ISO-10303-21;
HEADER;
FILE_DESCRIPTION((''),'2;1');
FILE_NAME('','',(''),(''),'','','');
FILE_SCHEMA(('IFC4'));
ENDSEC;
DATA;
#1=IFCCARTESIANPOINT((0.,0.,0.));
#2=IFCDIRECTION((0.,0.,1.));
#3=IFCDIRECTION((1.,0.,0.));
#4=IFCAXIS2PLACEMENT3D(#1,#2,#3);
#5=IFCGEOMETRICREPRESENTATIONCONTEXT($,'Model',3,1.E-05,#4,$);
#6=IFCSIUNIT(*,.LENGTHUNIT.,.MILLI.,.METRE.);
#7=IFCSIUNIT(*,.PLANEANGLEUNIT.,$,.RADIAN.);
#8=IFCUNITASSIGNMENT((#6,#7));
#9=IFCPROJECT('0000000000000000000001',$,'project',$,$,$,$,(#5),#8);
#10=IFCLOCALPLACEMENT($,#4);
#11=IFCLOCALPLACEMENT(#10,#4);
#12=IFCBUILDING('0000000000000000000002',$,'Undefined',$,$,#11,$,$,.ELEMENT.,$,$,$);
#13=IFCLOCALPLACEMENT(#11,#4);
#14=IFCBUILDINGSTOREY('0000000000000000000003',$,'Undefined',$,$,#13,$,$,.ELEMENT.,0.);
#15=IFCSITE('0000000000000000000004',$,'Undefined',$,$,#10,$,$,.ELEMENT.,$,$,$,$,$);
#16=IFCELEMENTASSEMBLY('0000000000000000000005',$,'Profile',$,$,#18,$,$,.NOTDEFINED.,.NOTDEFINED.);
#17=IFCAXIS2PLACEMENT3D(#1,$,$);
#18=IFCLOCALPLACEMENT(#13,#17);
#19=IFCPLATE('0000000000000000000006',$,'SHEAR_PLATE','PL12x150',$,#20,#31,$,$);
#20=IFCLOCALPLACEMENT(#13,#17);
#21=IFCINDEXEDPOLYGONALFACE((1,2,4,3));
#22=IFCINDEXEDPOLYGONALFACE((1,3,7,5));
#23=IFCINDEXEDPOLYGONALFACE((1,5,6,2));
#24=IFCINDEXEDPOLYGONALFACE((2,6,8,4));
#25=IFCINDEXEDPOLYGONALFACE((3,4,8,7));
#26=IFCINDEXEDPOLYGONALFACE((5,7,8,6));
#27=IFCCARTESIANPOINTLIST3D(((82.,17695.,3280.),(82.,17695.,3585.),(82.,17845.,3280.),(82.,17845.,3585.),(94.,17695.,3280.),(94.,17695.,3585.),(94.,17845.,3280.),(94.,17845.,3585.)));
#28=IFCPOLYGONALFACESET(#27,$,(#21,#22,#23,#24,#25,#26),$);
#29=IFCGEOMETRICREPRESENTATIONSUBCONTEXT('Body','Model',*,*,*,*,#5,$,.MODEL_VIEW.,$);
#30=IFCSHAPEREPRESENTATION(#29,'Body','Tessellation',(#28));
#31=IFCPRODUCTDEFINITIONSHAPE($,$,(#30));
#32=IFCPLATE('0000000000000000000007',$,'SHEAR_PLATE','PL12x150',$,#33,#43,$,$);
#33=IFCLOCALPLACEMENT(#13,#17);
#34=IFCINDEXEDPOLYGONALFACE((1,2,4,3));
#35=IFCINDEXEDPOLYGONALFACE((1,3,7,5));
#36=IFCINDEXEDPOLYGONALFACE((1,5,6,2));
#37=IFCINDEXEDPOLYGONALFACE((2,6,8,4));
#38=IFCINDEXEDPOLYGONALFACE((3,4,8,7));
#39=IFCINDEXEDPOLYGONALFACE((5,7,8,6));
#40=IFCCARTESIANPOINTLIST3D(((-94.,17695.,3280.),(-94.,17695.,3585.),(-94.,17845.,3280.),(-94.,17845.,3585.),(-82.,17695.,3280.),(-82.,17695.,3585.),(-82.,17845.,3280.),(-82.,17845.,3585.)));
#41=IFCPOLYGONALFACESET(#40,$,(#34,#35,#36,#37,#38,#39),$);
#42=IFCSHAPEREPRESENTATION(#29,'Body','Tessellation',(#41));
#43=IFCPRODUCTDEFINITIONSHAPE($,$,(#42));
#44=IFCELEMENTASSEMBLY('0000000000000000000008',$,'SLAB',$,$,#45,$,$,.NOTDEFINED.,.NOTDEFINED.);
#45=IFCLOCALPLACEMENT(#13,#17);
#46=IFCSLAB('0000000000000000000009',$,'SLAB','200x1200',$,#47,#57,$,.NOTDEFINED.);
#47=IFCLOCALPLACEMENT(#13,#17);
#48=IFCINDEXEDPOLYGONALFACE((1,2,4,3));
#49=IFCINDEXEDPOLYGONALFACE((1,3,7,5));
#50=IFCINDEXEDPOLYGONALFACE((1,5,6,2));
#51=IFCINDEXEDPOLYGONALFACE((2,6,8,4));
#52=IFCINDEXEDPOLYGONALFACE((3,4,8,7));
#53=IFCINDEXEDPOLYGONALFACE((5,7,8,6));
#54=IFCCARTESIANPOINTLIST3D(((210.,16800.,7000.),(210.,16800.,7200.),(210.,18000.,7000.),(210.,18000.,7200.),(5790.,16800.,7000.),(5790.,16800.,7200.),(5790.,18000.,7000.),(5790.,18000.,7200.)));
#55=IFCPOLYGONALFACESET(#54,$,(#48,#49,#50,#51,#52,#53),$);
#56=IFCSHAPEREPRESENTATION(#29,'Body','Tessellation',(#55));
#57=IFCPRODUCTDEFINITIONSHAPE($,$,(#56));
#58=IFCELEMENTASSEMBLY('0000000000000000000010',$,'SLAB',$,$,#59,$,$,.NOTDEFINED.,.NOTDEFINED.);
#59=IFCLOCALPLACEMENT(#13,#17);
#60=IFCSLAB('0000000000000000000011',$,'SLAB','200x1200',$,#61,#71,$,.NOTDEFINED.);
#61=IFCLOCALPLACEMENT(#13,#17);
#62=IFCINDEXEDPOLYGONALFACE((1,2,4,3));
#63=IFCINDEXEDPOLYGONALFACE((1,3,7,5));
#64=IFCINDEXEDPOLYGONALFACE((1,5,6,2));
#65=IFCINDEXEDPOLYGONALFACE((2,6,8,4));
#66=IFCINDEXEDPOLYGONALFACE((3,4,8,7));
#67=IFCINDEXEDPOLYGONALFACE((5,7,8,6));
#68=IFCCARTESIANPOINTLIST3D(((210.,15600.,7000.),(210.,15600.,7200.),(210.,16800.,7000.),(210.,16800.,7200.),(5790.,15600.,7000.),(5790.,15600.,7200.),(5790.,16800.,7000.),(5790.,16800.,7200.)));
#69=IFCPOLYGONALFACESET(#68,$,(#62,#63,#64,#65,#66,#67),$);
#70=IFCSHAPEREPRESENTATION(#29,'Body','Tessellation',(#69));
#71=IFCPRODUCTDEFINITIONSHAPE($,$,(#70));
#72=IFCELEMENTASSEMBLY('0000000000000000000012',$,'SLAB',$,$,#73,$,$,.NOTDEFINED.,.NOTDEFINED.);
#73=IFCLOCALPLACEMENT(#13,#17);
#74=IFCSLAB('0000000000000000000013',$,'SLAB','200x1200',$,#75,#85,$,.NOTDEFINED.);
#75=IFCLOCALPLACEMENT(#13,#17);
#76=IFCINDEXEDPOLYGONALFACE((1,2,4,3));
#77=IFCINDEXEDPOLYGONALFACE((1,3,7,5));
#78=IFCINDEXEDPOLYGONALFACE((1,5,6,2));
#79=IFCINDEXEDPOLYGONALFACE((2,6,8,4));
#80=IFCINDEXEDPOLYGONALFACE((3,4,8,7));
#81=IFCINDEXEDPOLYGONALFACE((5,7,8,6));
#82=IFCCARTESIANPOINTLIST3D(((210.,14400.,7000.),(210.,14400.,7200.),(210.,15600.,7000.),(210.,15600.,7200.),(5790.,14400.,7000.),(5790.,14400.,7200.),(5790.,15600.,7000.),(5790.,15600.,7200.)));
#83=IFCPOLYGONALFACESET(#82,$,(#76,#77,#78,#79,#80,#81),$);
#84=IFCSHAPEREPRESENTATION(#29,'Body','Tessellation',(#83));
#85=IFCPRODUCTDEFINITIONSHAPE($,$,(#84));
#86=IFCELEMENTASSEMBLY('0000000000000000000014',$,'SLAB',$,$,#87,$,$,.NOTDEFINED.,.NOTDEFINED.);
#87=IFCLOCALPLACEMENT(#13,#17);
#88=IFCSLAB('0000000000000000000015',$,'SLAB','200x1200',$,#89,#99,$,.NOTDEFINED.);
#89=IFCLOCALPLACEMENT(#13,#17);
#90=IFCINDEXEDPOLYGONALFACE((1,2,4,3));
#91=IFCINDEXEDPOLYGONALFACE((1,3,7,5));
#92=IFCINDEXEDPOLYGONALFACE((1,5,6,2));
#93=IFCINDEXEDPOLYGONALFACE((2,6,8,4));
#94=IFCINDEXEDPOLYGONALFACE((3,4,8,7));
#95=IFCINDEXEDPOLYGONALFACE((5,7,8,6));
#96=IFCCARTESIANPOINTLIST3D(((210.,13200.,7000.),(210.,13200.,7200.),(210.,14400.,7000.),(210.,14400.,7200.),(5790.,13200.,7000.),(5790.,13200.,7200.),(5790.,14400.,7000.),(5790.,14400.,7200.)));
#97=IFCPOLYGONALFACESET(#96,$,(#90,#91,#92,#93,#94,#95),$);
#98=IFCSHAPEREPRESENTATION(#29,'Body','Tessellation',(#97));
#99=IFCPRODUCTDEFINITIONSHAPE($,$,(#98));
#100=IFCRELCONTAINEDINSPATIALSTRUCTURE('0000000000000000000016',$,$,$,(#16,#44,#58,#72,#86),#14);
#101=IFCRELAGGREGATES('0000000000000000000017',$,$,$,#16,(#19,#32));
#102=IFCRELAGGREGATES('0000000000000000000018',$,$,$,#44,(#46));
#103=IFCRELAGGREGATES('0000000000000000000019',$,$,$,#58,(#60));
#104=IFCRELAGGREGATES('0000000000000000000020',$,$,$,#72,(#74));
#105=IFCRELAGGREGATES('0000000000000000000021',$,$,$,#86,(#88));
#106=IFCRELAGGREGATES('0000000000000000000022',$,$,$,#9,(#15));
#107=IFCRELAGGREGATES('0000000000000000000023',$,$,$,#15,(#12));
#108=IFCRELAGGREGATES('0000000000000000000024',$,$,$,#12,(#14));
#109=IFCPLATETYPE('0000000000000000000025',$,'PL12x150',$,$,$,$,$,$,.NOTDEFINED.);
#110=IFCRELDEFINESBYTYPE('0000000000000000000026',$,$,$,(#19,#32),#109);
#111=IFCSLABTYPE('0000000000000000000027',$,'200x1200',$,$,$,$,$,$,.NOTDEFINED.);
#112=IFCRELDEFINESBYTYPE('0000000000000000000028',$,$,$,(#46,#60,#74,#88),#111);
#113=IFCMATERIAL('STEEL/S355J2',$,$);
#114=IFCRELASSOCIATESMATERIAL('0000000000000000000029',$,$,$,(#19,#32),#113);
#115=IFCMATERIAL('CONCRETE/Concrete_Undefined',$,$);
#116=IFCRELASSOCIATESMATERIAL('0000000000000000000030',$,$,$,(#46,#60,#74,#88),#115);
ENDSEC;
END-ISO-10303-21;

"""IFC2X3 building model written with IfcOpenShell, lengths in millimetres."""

from ifc_helpers import new_model, si_unit, frame, origin_with_axes, place, context, subcontext, project, spatial, polyline, outline, extrude, material, type_object, element, aggregate, save


model = new_model("IFC2X3")

# Units and contexts
model_context = context("Model", 3, precision=1e-05, world=origin_with_axes())
body_context = subcontext(model_context, "Body", "Model", "MODEL_VIEW")
ifc_project = project(units=[si_unit("LENGTHUNIT", "METRE", prefix="MILLI"), si_unit("PLANEANGLEUNIT", "RADIAN")], contexts=[model_context])

# Site, building, storey
site_placement = place(None, origin_with_axes())
site = spatial("IfcSite", under=ifc_project, at=site_placement, Name="Undefined", CompositionType="ELEMENT")
building_placement = place(site_placement, origin_with_axes())
building = spatial("IfcBuilding", under=site, at=building_placement, Name="Undefined", CompositionType="ELEMENT")
storey_placement = place(building_placement, origin_with_axes())
storey = spatial("IfcBuildingStorey", under=building, at=storey_placement, Name="Undefined", CompositionType="ELEMENT", Elevation=0.0)

# Element assembly
ifc_material_1 = material(Name="STEEL/S355J2")
assembly_1_placement = place(storey_placement, origin_with_axes())
assembly_1 = element("IfcElementAssembly", 1, at=assembly_1_placement, inside=storey, Name="Profile", AssemblyPlace="NOTDEFINED", PredefinedType="NOTDEFINED")

# Plates
plate_type_1 = type_object("IfcPlateType", Name="PL12x150", PredefinedType="NOTDEFINED")
plate_1_placement = place(assembly_1_placement, frame((88.0, 17845.0, 3585.0), z_axis=(1.0, 0.0, 0.0), x_axis=(0.0, -1.0, 0.0)))
plate_1 = element("IfcPlate", 2, at=plate_1_placement, type_object=plate_type_1, material=ifc_material_1, Name="SHEAR_PLATE", Description="PL12x150", context=body_context, shape_type="SweptSolid", body=[
    extrude(outline(polyline([(0.0, 0.0), (150.0, 0.0), (150.0, 0.0), (150.0, 305.0), (150.0, 305.0), (0.0, 305.0), (0.0, 305.0), (0.0, 0.0)])), frame((0.0, 0.0, -6.0), z_axis=(0.0, 0.0, 1.0), x_axis=(1.0, 0.0, 0.0)), (0.0, 0.0, 1.0), 12.0),
])
plate_2_placement = place(assembly_1_placement, frame((-88.0, 17845.0, 3585.0), z_axis=(1.0, 0.0, 0.0), x_axis=(0.0, -1.0, 0.0)))
plate_2 = element("IfcPlate", 3, at=plate_2_placement, type_object=plate_type_1, material=ifc_material_1, Name="SHEAR_PLATE", Description="PL12x150", context=body_context, shape_type="SweptSolid", body=[
    extrude(outline(polyline([(0.0, 0.0), (150.0, 0.0), (150.0, 0.0), (150.0, 305.0), (150.0, 305.0), (0.0, 305.0), (0.0, 305.0), (0.0, 0.0)])), frame((0.0, 0.0, -6.0), z_axis=(0.0, 0.0, 1.0), x_axis=(1.0, 0.0, 0.0)), (0.0, 0.0, 1.0), 12.0),
])
aggregate(assembly_1, [plate_1, plate_2])

# Element assemblies, slabs
assembly_2_placement = place(storey_placement, origin_with_axes())
assembly_2 = element("IfcElementAssembly", 4, at=assembly_2_placement, inside=storey, Name="SLAB", AssemblyPlace="NOTDEFINED", PredefinedType="NOTDEFINED")
ifc_material_2 = material(Name="CONCRETE/Concrete_Undefined")
slab_type = type_object("IfcSlabType", Name="200x1200", PredefinedType="NOTDEFINED")
slab_1_placement = place(assembly_2_placement, frame((5790.0, 16800.0, 7100.0), z_axis=(0.0, 0.0, 1.0), x_axis=(0.0, 1.0, 0.0)))
slab_1 = element("IfcSlab", 5, at=slab_1_placement, type_object=slab_type, material=ifc_material_2, Name="SLAB", Description="200x1200", PredefinedType="NOTDEFINED", context=body_context, shape_type="SweptSolid", body=[
    extrude(outline(polyline([(0.0, 0.0), (1200.0, 0.0), (1200.0, 5580.0), (0.0, 5580.0), (0.0, 0.0)])), frame((0.0, 0.0, -100.0), z_axis=(0.0, 0.0, 1.0), x_axis=(1.0, 0.0, 0.0)), (0.0, 0.0, 1.0), 200.0),
])
aggregate(assembly_2, [slab_1])
assembly_3_placement = place(storey_placement, origin_with_axes())
assembly_3 = element("IfcElementAssembly", 6, at=assembly_3_placement, inside=storey, Name="SLAB", AssemblyPlace="NOTDEFINED", PredefinedType="NOTDEFINED")
slab_2_placement = place(assembly_3_placement, frame((5790.0, 15600.0, 7100.0), z_axis=(0.0, 0.0, 1.0), x_axis=(0.0, 1.0, 0.0)))
slab_2 = element("IfcSlab", 7, at=slab_2_placement, type_object=slab_type, material=ifc_material_2, Name="SLAB", Description="200x1200", PredefinedType="NOTDEFINED", context=body_context, shape_type="SweptSolid", body=[
    extrude(outline(polyline([(0.0, 0.0), (1200.0, 0.0), (1200.0, 5580.0), (0.0, 5580.0), (0.0, 0.0)])), frame((0.0, 0.0, -100.0), z_axis=(0.0, 0.0, 1.0), x_axis=(1.0, 0.0, 0.0)), (0.0, 0.0, 1.0), 200.0),
])
aggregate(assembly_3, [slab_2])
assembly_4_placement = place(storey_placement, origin_with_axes())
assembly_4 = element("IfcElementAssembly", 8, at=assembly_4_placement, inside=storey, Name="SLAB", AssemblyPlace="NOTDEFINED", PredefinedType="NOTDEFINED")
slab_3_placement = place(assembly_4_placement, frame((5790.0, 14400.0, 7100.0), z_axis=(0.0, 0.0, 1.0), x_axis=(0.0, 1.0, 0.0)))
slab_3 = element("IfcSlab", 9, at=slab_3_placement, type_object=slab_type, material=ifc_material_2, Name="SLAB", Description="200x1200", PredefinedType="NOTDEFINED", context=body_context, shape_type="SweptSolid", body=[
    extrude(outline(polyline([(0.0, 0.0), (1200.0, 0.0), (1200.0, 5580.0), (0.0, 5580.0), (0.0, 0.0)])), frame((0.0, 0.0, -100.0), z_axis=(0.0, 0.0, 1.0), x_axis=(1.0, 0.0, 0.0)), (0.0, 0.0, 1.0), 200.0),
])
aggregate(assembly_4, [slab_3])
assembly_5_placement = place(storey_placement, origin_with_axes())
assembly_5 = element("IfcElementAssembly", 10, at=assembly_5_placement, inside=storey, Name="SLAB", AssemblyPlace="NOTDEFINED", PredefinedType="NOTDEFINED")
slab_4_placement = place(assembly_5_placement, frame((5790.0, 13200.0, 7100.0), z_axis=(0.0, 0.0, 1.0), x_axis=(0.0, 1.0, 0.0)))
slab_4 = element("IfcSlab", 11, at=slab_4_placement, type_object=slab_type, material=ifc_material_2, Name="SLAB", Description="200x1200", PredefinedType="NOTDEFINED", context=body_context, shape_type="SweptSolid", body=[
    extrude(outline(polyline([(0.0, 0.0), (1200.0, 0.0), (1200.0, 5580.0), (0.0, 5580.0), (0.0, 0.0)])), frame((0.0, 0.0, -100.0), z_axis=(0.0, 0.0, 1.0), x_axis=(1.0, 0.0, 0.0)), (0.0, 0.0, 1.0), 200.0),
])
aggregate(assembly_5, [slab_4])

save(model, "model.ifc")
